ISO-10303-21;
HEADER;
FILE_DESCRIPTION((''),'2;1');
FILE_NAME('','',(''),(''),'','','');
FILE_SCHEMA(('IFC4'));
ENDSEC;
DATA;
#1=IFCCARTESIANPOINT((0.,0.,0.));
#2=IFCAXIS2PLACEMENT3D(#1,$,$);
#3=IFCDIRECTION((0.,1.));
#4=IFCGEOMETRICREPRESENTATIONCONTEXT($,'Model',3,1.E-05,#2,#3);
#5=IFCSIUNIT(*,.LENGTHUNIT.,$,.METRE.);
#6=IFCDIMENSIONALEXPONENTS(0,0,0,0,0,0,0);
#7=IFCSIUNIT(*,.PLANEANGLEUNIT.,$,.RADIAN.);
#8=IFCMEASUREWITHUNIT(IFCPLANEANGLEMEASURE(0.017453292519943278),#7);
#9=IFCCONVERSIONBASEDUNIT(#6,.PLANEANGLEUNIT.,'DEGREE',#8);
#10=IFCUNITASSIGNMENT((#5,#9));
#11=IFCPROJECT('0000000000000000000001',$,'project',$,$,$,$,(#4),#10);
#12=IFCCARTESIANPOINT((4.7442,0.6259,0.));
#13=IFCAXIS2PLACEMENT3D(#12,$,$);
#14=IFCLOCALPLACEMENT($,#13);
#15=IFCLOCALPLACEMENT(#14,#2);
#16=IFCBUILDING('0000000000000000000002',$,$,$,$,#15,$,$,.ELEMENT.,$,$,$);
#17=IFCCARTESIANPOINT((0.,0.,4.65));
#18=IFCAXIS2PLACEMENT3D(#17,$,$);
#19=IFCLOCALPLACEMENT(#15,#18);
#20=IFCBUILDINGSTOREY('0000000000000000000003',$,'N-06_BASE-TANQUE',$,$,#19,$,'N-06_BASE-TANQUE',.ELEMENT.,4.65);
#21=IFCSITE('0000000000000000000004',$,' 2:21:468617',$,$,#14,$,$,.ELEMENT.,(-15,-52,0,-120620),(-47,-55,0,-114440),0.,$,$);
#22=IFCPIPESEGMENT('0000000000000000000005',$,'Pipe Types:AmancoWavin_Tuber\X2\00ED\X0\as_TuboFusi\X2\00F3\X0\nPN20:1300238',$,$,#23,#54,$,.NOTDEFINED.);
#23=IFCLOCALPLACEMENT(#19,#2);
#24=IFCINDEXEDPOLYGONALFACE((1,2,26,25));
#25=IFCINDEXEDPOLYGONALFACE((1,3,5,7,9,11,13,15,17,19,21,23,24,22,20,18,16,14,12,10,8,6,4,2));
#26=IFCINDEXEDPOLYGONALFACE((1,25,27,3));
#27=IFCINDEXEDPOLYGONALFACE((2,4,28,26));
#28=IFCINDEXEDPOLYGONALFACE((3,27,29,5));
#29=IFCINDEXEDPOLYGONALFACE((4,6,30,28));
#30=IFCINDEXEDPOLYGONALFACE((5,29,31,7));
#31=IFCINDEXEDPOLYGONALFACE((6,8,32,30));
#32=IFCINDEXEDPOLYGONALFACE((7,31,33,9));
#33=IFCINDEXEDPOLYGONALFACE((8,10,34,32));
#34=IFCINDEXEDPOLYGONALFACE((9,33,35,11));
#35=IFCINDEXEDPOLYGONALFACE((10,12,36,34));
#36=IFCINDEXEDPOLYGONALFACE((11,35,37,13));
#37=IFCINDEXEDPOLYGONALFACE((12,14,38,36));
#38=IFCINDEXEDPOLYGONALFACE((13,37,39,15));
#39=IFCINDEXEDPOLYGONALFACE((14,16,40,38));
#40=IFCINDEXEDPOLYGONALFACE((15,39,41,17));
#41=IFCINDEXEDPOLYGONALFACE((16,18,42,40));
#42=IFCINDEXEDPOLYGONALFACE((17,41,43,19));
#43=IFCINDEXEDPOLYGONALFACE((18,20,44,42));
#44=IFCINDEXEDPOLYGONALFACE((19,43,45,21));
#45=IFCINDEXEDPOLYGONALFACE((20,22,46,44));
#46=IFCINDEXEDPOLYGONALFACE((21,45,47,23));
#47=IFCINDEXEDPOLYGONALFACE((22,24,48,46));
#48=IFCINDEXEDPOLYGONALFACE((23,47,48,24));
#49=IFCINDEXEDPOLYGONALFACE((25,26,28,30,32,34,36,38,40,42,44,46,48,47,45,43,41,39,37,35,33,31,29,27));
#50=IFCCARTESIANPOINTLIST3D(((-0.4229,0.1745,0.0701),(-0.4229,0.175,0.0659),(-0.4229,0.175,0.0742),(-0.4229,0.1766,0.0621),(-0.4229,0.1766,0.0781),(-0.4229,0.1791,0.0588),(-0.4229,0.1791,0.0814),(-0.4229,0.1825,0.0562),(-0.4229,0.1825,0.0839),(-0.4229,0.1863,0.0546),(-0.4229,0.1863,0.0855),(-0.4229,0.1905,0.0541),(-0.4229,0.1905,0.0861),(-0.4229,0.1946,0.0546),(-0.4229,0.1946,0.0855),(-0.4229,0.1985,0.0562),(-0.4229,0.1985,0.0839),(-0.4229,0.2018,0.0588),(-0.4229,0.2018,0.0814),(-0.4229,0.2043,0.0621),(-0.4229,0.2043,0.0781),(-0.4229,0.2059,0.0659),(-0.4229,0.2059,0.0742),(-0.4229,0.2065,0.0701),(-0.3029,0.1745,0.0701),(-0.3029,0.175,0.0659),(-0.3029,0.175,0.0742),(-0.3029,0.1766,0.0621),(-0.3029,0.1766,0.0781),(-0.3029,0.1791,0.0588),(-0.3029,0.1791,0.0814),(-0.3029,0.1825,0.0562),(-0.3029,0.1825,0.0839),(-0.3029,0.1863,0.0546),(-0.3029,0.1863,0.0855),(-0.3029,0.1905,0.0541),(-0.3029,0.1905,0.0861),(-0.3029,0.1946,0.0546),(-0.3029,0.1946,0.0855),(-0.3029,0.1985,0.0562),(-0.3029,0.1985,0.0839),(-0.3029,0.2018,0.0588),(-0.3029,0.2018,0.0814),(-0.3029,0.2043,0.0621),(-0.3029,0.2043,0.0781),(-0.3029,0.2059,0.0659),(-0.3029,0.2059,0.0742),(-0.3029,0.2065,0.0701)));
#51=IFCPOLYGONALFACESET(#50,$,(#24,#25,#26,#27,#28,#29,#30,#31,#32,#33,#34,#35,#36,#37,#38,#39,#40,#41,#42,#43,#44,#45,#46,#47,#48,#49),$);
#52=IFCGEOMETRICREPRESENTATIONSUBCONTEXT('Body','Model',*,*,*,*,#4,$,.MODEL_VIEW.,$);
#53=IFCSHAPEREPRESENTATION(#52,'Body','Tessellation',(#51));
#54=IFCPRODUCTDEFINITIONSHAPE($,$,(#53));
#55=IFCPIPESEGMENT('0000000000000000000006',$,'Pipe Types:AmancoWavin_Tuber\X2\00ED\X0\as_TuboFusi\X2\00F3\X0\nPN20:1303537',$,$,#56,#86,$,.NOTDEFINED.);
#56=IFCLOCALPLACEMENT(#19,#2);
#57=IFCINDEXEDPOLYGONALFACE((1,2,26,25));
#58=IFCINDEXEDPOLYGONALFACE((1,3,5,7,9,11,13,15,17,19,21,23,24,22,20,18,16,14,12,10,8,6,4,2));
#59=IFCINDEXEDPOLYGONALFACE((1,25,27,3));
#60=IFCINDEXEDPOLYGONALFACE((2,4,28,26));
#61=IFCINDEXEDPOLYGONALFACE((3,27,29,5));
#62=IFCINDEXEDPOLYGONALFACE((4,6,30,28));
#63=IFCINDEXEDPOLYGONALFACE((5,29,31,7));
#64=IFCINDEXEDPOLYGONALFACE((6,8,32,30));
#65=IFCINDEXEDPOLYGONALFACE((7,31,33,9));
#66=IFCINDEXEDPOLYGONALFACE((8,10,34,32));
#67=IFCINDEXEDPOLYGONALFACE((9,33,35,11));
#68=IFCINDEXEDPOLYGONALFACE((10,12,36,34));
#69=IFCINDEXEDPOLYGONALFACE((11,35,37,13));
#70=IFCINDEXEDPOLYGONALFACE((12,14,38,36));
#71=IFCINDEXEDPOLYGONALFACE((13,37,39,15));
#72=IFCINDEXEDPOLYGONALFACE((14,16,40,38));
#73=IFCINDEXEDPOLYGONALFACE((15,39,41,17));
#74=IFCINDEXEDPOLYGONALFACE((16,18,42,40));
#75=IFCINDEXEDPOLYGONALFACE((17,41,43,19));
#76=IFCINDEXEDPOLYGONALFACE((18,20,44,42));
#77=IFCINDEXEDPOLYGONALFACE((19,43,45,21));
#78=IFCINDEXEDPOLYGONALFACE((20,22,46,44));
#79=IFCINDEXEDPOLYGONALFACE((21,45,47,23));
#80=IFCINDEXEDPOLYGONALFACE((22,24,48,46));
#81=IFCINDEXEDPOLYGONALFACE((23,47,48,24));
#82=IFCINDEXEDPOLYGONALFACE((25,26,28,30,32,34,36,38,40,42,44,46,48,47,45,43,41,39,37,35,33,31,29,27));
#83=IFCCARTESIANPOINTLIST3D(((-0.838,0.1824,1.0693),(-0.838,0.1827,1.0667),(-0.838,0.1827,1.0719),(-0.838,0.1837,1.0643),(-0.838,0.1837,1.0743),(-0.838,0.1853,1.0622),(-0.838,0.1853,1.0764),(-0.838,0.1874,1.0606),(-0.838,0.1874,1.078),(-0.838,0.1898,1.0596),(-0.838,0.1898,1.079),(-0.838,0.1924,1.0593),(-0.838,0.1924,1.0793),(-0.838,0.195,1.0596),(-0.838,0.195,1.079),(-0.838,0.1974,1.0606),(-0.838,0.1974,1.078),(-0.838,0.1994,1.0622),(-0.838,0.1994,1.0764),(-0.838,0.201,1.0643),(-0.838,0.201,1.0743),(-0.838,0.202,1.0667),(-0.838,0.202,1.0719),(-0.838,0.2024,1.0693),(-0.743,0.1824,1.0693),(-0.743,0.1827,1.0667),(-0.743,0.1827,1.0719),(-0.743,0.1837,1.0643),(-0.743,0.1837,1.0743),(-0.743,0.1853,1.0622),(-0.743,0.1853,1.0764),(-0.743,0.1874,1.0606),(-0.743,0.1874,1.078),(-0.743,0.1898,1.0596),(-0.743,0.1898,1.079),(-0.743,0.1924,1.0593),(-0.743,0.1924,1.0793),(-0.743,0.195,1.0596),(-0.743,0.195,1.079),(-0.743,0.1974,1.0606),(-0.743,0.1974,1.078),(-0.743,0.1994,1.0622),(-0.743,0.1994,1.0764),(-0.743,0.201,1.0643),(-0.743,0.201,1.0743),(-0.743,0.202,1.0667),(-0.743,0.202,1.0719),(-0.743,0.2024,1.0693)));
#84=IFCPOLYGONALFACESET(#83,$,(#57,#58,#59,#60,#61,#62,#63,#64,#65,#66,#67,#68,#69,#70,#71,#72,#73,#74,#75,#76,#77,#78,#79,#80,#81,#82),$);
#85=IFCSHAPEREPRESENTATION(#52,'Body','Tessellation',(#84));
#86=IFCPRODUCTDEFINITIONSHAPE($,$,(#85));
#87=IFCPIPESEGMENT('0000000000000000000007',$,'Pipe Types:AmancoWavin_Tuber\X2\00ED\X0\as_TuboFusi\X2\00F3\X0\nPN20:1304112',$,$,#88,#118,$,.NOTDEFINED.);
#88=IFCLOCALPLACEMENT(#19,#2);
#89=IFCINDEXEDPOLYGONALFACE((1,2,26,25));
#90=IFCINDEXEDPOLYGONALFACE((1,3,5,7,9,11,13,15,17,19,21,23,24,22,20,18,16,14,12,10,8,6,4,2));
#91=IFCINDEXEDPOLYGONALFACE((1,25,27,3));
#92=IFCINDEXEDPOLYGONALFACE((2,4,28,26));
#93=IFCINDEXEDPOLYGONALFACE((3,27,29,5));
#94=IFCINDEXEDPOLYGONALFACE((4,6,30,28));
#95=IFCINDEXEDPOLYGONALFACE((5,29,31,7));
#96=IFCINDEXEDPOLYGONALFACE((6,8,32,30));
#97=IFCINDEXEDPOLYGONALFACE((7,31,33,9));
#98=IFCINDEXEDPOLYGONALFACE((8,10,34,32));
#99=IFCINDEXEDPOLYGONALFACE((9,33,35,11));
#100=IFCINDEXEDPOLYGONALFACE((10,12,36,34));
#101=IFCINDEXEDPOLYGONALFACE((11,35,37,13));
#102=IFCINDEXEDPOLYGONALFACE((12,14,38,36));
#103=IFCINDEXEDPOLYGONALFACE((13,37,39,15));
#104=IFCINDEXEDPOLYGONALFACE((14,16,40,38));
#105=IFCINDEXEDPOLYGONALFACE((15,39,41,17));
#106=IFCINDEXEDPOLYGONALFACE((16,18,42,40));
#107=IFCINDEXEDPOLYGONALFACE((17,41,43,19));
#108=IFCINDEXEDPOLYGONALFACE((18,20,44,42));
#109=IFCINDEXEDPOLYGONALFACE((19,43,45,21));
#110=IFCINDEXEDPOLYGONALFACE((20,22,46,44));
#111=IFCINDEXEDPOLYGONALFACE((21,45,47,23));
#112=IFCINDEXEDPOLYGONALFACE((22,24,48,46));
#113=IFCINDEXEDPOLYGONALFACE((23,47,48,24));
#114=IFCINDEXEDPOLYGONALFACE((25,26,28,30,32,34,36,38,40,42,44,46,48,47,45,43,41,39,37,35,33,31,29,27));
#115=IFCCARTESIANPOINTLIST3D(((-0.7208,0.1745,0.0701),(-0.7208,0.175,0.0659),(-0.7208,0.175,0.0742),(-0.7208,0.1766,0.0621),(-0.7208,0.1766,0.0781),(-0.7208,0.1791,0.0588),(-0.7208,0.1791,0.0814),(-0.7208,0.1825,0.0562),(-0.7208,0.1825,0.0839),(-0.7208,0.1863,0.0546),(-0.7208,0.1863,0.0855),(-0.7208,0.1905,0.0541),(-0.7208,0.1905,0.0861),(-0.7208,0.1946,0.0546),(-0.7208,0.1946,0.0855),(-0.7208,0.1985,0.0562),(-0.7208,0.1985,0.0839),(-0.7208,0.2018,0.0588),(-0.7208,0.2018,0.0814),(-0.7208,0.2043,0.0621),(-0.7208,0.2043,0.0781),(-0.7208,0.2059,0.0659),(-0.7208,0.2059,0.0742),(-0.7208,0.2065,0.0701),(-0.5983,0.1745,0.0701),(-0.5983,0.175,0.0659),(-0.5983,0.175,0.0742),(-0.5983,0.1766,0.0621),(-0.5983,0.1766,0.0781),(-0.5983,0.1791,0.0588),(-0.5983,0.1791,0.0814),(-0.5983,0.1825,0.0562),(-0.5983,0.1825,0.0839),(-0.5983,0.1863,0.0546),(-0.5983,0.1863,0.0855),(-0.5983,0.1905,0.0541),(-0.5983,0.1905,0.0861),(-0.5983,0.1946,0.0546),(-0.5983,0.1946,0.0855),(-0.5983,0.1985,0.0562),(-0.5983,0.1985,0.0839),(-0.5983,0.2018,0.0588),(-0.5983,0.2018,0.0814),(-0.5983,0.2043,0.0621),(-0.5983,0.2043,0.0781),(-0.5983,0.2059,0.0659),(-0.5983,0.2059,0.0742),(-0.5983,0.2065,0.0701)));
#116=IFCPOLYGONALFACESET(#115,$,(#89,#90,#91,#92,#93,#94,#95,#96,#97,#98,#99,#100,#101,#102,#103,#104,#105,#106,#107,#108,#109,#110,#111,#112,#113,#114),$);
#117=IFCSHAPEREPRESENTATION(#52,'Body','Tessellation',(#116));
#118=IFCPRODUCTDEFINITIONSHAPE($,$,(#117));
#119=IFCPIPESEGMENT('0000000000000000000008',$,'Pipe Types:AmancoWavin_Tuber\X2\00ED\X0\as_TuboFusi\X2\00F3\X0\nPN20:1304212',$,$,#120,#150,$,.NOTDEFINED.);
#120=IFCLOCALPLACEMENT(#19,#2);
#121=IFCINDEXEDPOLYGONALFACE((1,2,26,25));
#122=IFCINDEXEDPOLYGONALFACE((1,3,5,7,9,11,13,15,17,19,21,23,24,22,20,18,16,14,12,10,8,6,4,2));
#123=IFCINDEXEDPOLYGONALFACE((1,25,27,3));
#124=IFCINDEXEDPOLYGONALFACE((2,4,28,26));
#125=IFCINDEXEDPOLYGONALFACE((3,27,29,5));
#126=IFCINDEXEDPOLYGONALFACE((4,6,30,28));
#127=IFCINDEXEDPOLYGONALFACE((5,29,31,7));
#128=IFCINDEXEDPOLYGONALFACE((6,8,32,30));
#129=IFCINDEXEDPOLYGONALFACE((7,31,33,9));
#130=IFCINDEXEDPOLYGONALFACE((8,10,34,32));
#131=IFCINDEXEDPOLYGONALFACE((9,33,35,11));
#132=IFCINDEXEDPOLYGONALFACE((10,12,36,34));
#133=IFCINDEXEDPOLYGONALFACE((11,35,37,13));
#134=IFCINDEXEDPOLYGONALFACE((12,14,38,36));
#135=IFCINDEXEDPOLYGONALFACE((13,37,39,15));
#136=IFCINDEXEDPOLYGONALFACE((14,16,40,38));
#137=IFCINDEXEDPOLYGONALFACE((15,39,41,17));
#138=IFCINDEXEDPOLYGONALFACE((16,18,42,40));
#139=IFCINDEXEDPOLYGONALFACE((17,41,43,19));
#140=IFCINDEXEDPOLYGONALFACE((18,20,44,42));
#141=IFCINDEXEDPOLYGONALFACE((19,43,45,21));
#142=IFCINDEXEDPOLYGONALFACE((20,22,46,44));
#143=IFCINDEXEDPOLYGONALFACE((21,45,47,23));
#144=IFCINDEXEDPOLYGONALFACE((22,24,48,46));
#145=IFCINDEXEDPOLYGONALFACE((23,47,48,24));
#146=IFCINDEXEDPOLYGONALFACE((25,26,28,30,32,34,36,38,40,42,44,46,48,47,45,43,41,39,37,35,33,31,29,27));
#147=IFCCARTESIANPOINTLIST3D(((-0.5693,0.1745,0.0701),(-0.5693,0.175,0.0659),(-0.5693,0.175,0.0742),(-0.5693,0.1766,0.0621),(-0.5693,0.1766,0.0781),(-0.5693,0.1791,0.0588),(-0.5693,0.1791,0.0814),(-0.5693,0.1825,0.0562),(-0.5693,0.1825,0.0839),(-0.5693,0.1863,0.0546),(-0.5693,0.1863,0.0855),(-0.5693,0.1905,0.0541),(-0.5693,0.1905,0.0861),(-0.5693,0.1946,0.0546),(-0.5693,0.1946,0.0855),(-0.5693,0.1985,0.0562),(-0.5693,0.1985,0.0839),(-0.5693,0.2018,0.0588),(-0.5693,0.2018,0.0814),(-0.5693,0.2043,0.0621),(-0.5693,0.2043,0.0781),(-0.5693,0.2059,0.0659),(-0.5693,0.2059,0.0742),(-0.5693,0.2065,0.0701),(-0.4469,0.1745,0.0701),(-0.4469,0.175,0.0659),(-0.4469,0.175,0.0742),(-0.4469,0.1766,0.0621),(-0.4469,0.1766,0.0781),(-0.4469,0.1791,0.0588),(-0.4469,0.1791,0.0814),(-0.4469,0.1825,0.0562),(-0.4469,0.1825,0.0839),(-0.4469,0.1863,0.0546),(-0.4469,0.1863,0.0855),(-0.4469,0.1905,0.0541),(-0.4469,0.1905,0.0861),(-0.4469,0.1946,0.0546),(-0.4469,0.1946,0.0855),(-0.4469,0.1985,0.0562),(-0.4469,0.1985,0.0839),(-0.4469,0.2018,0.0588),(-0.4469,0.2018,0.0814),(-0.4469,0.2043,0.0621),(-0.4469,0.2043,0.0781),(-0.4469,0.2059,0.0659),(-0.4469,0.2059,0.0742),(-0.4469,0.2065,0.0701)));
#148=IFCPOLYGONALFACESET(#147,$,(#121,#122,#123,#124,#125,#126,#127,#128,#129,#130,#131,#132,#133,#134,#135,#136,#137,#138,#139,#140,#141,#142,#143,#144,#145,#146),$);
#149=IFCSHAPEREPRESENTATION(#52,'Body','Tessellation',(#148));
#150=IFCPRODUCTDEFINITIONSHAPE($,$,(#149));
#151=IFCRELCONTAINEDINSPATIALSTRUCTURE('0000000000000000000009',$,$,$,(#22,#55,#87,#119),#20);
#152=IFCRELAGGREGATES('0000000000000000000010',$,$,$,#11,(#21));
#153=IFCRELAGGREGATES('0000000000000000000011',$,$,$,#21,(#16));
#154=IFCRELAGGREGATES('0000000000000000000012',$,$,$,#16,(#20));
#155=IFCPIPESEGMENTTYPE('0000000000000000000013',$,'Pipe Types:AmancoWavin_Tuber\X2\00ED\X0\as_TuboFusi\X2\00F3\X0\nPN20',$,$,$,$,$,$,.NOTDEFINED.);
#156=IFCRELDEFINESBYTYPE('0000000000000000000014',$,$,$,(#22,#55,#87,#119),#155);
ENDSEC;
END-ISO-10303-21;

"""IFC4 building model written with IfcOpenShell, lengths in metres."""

from ifc_helpers import new_model, entity, si_unit, converted_unit, direction, frame, origin, place, context, subcontext, project, spatial, arc, indexed_curve, outline, extrude, type_object, element, save


model = new_model("IFC4")

# Units and contexts
model_context = context("Model", 3, precision=1e-05, world=origin(), true_north=direction((0.0, 1.0)))
body_context = subcontext(model_context, "Body", "Model", "MODEL_VIEW")
ifc_project = project(units=[si_unit("LENGTHUNIT", "METRE"), converted_unit("PLANEANGLEUNIT", "DEGREE", entity("IfcPlaneAngleMeasure", 0.017453292519943278), si_unit("PLANEANGLEUNIT", "RADIAN"), dimensions=[0, 0, 0, 0, 0, 0, 0])], contexts=[model_context])

# Site, building, storey
site_placement = place(None, frame((4.7442, 0.6259, 0.0)))
site = spatial("IfcSite", under=ifc_project, at=site_placement, Name=" 2:21:468617", CompositionType="ELEMENT", RefLatitude=(-15, -52, 0, -120620), RefLongitude=(-47, -55, 0, -114440), RefElevation=0.0)
building_placement = place(site_placement, origin())
building = spatial("IfcBuilding", under=site, at=building_placement, CompositionType="ELEMENT")
storey_placement = place(building_placement, frame((0.0, 0.0, 4.65)))
storey = spatial("IfcBuildingStorey", under=building, at=storey_placement, Name="N-06_BASE-TANQUE", LongName="N-06_BASE-TANQUE", CompositionType="ELEMENT", Elevation=4.65)

# Pipe segments
pipe_segment_type = type_object("IfcPipeSegmentType", Name="Pipe Types:AmancoWavin_Tuberías_TuboFusiónPN20", PredefinedType="NOTDEFINED")
pipe_segment_1_placement = place(storey_placement, origin())
element("IfcPipeSegment", 1, at=pipe_segment_1_placement, inside=storey, type_object=pipe_segment_type, Name="Pipe Types:AmancoWavin_Tuberías_TuboFusiónPN20:1300238", PredefinedType="NOTDEFINED", context=body_context, shape_type="SweptSolid", body=[
    extrude(outline(indexed_curve([(0.016, 0.0), (0.0113, 0.0113), (0.0, 0.016), (-0.0113, 0.0113), (-0.016, 0.0), (-0.0113, -0.0113), (0.0, -0.016), (0.0113, -0.0113)], segments=[arc(1, 2, 3), arc(3, 4, 5), arc(5, 6, 7), arc(7, 8, 1)], self_intersect=False)), frame((-0.4229, 0.1905, 0.0701), z_axis=(1.0, 0.0, 0.0), x_axis=(0.0, -1.0, 0.0)), (0.0, 0.0, 1.0), 0.12),
])
pipe_segment_2_placement = place(storey_placement, origin())
element("IfcPipeSegment", 2, at=pipe_segment_2_placement, inside=storey, type_object=pipe_segment_type, Name="Pipe Types:AmancoWavin_Tuberías_TuboFusiónPN20:1303537", PredefinedType="NOTDEFINED", context=body_context, shape_type="SweptSolid", body=[
    extrude(outline(indexed_curve([(0.01, 0.0), (0.0071, 0.0071), (0.0, 0.01), (-0.0071, 0.0071), (-0.01, 0.0), (-0.0071, -0.0071), (0.0, -0.01), (0.0071, -0.0071)], segments=[arc(1, 2, 3), arc(3, 4, 5), arc(5, 6, 7), arc(7, 8, 1)], self_intersect=False)), frame((-0.838, 0.1924, 1.0693), z_axis=(1.0, 0.0, 0.0), x_axis=(0.0, -1.0, 0.0)), (0.0, 0.0, 1.0), 0.095),
])
pipe_segment_3_placement = place(storey_placement, origin())
element("IfcPipeSegment", 3, at=pipe_segment_3_placement, inside=storey, type_object=pipe_segment_type, Name="Pipe Types:AmancoWavin_Tuberías_TuboFusiónPN20:1304112", PredefinedType="NOTDEFINED", context=body_context, shape_type="SweptSolid", body=[
    extrude(outline(indexed_curve([(0.016, 0.0), (0.0113, 0.0113), (0.0, 0.016), (-0.0113, 0.0113), (-0.016, 0.0), (-0.0113, -0.0113), (0.0, -0.016), (0.0113, -0.0113)], segments=[arc(1, 2, 3), arc(3, 4, 5), arc(5, 6, 7), arc(7, 8, 1)], self_intersect=False)), frame((-0.7208, 0.1905, 0.0701), z_axis=(1.0, 0.0, 0.0), x_axis=(0.0, 1.0, 0.0)), (0.0, 0.0, 1.0), 0.1225),
])
pipe_segment_4_placement = place(storey_placement, origin())
element("IfcPipeSegment", 4, at=pipe_segment_4_placement, inside=storey, type_object=pipe_segment_type, Name="Pipe Types:AmancoWavin_Tuberías_TuboFusiónPN20:1304212", PredefinedType="NOTDEFINED", context=body_context, shape_type="SweptSolid", body=[
    extrude(outline(indexed_curve([(0.016, 0.0), (0.0113, 0.0113), (0.0, 0.016), (-0.0113, 0.0113), (-0.016, 0.0), (-0.0113, -0.0113), (0.0, -0.016), (0.0113, -0.0113)], segments=[arc(1, 2, 3), arc(3, 4, 5), arc(5, 6, 7), arc(7, 8, 1)], self_intersect=False)), frame((-0.5693, 0.1905, 0.0701), z_axis=(1.0, 0.0, 0.0), x_axis=(0.0, 1.0, 0.0)), (0.0, 0.0, 1.0), 0.1225),
])

save(model, "model.ifc")
